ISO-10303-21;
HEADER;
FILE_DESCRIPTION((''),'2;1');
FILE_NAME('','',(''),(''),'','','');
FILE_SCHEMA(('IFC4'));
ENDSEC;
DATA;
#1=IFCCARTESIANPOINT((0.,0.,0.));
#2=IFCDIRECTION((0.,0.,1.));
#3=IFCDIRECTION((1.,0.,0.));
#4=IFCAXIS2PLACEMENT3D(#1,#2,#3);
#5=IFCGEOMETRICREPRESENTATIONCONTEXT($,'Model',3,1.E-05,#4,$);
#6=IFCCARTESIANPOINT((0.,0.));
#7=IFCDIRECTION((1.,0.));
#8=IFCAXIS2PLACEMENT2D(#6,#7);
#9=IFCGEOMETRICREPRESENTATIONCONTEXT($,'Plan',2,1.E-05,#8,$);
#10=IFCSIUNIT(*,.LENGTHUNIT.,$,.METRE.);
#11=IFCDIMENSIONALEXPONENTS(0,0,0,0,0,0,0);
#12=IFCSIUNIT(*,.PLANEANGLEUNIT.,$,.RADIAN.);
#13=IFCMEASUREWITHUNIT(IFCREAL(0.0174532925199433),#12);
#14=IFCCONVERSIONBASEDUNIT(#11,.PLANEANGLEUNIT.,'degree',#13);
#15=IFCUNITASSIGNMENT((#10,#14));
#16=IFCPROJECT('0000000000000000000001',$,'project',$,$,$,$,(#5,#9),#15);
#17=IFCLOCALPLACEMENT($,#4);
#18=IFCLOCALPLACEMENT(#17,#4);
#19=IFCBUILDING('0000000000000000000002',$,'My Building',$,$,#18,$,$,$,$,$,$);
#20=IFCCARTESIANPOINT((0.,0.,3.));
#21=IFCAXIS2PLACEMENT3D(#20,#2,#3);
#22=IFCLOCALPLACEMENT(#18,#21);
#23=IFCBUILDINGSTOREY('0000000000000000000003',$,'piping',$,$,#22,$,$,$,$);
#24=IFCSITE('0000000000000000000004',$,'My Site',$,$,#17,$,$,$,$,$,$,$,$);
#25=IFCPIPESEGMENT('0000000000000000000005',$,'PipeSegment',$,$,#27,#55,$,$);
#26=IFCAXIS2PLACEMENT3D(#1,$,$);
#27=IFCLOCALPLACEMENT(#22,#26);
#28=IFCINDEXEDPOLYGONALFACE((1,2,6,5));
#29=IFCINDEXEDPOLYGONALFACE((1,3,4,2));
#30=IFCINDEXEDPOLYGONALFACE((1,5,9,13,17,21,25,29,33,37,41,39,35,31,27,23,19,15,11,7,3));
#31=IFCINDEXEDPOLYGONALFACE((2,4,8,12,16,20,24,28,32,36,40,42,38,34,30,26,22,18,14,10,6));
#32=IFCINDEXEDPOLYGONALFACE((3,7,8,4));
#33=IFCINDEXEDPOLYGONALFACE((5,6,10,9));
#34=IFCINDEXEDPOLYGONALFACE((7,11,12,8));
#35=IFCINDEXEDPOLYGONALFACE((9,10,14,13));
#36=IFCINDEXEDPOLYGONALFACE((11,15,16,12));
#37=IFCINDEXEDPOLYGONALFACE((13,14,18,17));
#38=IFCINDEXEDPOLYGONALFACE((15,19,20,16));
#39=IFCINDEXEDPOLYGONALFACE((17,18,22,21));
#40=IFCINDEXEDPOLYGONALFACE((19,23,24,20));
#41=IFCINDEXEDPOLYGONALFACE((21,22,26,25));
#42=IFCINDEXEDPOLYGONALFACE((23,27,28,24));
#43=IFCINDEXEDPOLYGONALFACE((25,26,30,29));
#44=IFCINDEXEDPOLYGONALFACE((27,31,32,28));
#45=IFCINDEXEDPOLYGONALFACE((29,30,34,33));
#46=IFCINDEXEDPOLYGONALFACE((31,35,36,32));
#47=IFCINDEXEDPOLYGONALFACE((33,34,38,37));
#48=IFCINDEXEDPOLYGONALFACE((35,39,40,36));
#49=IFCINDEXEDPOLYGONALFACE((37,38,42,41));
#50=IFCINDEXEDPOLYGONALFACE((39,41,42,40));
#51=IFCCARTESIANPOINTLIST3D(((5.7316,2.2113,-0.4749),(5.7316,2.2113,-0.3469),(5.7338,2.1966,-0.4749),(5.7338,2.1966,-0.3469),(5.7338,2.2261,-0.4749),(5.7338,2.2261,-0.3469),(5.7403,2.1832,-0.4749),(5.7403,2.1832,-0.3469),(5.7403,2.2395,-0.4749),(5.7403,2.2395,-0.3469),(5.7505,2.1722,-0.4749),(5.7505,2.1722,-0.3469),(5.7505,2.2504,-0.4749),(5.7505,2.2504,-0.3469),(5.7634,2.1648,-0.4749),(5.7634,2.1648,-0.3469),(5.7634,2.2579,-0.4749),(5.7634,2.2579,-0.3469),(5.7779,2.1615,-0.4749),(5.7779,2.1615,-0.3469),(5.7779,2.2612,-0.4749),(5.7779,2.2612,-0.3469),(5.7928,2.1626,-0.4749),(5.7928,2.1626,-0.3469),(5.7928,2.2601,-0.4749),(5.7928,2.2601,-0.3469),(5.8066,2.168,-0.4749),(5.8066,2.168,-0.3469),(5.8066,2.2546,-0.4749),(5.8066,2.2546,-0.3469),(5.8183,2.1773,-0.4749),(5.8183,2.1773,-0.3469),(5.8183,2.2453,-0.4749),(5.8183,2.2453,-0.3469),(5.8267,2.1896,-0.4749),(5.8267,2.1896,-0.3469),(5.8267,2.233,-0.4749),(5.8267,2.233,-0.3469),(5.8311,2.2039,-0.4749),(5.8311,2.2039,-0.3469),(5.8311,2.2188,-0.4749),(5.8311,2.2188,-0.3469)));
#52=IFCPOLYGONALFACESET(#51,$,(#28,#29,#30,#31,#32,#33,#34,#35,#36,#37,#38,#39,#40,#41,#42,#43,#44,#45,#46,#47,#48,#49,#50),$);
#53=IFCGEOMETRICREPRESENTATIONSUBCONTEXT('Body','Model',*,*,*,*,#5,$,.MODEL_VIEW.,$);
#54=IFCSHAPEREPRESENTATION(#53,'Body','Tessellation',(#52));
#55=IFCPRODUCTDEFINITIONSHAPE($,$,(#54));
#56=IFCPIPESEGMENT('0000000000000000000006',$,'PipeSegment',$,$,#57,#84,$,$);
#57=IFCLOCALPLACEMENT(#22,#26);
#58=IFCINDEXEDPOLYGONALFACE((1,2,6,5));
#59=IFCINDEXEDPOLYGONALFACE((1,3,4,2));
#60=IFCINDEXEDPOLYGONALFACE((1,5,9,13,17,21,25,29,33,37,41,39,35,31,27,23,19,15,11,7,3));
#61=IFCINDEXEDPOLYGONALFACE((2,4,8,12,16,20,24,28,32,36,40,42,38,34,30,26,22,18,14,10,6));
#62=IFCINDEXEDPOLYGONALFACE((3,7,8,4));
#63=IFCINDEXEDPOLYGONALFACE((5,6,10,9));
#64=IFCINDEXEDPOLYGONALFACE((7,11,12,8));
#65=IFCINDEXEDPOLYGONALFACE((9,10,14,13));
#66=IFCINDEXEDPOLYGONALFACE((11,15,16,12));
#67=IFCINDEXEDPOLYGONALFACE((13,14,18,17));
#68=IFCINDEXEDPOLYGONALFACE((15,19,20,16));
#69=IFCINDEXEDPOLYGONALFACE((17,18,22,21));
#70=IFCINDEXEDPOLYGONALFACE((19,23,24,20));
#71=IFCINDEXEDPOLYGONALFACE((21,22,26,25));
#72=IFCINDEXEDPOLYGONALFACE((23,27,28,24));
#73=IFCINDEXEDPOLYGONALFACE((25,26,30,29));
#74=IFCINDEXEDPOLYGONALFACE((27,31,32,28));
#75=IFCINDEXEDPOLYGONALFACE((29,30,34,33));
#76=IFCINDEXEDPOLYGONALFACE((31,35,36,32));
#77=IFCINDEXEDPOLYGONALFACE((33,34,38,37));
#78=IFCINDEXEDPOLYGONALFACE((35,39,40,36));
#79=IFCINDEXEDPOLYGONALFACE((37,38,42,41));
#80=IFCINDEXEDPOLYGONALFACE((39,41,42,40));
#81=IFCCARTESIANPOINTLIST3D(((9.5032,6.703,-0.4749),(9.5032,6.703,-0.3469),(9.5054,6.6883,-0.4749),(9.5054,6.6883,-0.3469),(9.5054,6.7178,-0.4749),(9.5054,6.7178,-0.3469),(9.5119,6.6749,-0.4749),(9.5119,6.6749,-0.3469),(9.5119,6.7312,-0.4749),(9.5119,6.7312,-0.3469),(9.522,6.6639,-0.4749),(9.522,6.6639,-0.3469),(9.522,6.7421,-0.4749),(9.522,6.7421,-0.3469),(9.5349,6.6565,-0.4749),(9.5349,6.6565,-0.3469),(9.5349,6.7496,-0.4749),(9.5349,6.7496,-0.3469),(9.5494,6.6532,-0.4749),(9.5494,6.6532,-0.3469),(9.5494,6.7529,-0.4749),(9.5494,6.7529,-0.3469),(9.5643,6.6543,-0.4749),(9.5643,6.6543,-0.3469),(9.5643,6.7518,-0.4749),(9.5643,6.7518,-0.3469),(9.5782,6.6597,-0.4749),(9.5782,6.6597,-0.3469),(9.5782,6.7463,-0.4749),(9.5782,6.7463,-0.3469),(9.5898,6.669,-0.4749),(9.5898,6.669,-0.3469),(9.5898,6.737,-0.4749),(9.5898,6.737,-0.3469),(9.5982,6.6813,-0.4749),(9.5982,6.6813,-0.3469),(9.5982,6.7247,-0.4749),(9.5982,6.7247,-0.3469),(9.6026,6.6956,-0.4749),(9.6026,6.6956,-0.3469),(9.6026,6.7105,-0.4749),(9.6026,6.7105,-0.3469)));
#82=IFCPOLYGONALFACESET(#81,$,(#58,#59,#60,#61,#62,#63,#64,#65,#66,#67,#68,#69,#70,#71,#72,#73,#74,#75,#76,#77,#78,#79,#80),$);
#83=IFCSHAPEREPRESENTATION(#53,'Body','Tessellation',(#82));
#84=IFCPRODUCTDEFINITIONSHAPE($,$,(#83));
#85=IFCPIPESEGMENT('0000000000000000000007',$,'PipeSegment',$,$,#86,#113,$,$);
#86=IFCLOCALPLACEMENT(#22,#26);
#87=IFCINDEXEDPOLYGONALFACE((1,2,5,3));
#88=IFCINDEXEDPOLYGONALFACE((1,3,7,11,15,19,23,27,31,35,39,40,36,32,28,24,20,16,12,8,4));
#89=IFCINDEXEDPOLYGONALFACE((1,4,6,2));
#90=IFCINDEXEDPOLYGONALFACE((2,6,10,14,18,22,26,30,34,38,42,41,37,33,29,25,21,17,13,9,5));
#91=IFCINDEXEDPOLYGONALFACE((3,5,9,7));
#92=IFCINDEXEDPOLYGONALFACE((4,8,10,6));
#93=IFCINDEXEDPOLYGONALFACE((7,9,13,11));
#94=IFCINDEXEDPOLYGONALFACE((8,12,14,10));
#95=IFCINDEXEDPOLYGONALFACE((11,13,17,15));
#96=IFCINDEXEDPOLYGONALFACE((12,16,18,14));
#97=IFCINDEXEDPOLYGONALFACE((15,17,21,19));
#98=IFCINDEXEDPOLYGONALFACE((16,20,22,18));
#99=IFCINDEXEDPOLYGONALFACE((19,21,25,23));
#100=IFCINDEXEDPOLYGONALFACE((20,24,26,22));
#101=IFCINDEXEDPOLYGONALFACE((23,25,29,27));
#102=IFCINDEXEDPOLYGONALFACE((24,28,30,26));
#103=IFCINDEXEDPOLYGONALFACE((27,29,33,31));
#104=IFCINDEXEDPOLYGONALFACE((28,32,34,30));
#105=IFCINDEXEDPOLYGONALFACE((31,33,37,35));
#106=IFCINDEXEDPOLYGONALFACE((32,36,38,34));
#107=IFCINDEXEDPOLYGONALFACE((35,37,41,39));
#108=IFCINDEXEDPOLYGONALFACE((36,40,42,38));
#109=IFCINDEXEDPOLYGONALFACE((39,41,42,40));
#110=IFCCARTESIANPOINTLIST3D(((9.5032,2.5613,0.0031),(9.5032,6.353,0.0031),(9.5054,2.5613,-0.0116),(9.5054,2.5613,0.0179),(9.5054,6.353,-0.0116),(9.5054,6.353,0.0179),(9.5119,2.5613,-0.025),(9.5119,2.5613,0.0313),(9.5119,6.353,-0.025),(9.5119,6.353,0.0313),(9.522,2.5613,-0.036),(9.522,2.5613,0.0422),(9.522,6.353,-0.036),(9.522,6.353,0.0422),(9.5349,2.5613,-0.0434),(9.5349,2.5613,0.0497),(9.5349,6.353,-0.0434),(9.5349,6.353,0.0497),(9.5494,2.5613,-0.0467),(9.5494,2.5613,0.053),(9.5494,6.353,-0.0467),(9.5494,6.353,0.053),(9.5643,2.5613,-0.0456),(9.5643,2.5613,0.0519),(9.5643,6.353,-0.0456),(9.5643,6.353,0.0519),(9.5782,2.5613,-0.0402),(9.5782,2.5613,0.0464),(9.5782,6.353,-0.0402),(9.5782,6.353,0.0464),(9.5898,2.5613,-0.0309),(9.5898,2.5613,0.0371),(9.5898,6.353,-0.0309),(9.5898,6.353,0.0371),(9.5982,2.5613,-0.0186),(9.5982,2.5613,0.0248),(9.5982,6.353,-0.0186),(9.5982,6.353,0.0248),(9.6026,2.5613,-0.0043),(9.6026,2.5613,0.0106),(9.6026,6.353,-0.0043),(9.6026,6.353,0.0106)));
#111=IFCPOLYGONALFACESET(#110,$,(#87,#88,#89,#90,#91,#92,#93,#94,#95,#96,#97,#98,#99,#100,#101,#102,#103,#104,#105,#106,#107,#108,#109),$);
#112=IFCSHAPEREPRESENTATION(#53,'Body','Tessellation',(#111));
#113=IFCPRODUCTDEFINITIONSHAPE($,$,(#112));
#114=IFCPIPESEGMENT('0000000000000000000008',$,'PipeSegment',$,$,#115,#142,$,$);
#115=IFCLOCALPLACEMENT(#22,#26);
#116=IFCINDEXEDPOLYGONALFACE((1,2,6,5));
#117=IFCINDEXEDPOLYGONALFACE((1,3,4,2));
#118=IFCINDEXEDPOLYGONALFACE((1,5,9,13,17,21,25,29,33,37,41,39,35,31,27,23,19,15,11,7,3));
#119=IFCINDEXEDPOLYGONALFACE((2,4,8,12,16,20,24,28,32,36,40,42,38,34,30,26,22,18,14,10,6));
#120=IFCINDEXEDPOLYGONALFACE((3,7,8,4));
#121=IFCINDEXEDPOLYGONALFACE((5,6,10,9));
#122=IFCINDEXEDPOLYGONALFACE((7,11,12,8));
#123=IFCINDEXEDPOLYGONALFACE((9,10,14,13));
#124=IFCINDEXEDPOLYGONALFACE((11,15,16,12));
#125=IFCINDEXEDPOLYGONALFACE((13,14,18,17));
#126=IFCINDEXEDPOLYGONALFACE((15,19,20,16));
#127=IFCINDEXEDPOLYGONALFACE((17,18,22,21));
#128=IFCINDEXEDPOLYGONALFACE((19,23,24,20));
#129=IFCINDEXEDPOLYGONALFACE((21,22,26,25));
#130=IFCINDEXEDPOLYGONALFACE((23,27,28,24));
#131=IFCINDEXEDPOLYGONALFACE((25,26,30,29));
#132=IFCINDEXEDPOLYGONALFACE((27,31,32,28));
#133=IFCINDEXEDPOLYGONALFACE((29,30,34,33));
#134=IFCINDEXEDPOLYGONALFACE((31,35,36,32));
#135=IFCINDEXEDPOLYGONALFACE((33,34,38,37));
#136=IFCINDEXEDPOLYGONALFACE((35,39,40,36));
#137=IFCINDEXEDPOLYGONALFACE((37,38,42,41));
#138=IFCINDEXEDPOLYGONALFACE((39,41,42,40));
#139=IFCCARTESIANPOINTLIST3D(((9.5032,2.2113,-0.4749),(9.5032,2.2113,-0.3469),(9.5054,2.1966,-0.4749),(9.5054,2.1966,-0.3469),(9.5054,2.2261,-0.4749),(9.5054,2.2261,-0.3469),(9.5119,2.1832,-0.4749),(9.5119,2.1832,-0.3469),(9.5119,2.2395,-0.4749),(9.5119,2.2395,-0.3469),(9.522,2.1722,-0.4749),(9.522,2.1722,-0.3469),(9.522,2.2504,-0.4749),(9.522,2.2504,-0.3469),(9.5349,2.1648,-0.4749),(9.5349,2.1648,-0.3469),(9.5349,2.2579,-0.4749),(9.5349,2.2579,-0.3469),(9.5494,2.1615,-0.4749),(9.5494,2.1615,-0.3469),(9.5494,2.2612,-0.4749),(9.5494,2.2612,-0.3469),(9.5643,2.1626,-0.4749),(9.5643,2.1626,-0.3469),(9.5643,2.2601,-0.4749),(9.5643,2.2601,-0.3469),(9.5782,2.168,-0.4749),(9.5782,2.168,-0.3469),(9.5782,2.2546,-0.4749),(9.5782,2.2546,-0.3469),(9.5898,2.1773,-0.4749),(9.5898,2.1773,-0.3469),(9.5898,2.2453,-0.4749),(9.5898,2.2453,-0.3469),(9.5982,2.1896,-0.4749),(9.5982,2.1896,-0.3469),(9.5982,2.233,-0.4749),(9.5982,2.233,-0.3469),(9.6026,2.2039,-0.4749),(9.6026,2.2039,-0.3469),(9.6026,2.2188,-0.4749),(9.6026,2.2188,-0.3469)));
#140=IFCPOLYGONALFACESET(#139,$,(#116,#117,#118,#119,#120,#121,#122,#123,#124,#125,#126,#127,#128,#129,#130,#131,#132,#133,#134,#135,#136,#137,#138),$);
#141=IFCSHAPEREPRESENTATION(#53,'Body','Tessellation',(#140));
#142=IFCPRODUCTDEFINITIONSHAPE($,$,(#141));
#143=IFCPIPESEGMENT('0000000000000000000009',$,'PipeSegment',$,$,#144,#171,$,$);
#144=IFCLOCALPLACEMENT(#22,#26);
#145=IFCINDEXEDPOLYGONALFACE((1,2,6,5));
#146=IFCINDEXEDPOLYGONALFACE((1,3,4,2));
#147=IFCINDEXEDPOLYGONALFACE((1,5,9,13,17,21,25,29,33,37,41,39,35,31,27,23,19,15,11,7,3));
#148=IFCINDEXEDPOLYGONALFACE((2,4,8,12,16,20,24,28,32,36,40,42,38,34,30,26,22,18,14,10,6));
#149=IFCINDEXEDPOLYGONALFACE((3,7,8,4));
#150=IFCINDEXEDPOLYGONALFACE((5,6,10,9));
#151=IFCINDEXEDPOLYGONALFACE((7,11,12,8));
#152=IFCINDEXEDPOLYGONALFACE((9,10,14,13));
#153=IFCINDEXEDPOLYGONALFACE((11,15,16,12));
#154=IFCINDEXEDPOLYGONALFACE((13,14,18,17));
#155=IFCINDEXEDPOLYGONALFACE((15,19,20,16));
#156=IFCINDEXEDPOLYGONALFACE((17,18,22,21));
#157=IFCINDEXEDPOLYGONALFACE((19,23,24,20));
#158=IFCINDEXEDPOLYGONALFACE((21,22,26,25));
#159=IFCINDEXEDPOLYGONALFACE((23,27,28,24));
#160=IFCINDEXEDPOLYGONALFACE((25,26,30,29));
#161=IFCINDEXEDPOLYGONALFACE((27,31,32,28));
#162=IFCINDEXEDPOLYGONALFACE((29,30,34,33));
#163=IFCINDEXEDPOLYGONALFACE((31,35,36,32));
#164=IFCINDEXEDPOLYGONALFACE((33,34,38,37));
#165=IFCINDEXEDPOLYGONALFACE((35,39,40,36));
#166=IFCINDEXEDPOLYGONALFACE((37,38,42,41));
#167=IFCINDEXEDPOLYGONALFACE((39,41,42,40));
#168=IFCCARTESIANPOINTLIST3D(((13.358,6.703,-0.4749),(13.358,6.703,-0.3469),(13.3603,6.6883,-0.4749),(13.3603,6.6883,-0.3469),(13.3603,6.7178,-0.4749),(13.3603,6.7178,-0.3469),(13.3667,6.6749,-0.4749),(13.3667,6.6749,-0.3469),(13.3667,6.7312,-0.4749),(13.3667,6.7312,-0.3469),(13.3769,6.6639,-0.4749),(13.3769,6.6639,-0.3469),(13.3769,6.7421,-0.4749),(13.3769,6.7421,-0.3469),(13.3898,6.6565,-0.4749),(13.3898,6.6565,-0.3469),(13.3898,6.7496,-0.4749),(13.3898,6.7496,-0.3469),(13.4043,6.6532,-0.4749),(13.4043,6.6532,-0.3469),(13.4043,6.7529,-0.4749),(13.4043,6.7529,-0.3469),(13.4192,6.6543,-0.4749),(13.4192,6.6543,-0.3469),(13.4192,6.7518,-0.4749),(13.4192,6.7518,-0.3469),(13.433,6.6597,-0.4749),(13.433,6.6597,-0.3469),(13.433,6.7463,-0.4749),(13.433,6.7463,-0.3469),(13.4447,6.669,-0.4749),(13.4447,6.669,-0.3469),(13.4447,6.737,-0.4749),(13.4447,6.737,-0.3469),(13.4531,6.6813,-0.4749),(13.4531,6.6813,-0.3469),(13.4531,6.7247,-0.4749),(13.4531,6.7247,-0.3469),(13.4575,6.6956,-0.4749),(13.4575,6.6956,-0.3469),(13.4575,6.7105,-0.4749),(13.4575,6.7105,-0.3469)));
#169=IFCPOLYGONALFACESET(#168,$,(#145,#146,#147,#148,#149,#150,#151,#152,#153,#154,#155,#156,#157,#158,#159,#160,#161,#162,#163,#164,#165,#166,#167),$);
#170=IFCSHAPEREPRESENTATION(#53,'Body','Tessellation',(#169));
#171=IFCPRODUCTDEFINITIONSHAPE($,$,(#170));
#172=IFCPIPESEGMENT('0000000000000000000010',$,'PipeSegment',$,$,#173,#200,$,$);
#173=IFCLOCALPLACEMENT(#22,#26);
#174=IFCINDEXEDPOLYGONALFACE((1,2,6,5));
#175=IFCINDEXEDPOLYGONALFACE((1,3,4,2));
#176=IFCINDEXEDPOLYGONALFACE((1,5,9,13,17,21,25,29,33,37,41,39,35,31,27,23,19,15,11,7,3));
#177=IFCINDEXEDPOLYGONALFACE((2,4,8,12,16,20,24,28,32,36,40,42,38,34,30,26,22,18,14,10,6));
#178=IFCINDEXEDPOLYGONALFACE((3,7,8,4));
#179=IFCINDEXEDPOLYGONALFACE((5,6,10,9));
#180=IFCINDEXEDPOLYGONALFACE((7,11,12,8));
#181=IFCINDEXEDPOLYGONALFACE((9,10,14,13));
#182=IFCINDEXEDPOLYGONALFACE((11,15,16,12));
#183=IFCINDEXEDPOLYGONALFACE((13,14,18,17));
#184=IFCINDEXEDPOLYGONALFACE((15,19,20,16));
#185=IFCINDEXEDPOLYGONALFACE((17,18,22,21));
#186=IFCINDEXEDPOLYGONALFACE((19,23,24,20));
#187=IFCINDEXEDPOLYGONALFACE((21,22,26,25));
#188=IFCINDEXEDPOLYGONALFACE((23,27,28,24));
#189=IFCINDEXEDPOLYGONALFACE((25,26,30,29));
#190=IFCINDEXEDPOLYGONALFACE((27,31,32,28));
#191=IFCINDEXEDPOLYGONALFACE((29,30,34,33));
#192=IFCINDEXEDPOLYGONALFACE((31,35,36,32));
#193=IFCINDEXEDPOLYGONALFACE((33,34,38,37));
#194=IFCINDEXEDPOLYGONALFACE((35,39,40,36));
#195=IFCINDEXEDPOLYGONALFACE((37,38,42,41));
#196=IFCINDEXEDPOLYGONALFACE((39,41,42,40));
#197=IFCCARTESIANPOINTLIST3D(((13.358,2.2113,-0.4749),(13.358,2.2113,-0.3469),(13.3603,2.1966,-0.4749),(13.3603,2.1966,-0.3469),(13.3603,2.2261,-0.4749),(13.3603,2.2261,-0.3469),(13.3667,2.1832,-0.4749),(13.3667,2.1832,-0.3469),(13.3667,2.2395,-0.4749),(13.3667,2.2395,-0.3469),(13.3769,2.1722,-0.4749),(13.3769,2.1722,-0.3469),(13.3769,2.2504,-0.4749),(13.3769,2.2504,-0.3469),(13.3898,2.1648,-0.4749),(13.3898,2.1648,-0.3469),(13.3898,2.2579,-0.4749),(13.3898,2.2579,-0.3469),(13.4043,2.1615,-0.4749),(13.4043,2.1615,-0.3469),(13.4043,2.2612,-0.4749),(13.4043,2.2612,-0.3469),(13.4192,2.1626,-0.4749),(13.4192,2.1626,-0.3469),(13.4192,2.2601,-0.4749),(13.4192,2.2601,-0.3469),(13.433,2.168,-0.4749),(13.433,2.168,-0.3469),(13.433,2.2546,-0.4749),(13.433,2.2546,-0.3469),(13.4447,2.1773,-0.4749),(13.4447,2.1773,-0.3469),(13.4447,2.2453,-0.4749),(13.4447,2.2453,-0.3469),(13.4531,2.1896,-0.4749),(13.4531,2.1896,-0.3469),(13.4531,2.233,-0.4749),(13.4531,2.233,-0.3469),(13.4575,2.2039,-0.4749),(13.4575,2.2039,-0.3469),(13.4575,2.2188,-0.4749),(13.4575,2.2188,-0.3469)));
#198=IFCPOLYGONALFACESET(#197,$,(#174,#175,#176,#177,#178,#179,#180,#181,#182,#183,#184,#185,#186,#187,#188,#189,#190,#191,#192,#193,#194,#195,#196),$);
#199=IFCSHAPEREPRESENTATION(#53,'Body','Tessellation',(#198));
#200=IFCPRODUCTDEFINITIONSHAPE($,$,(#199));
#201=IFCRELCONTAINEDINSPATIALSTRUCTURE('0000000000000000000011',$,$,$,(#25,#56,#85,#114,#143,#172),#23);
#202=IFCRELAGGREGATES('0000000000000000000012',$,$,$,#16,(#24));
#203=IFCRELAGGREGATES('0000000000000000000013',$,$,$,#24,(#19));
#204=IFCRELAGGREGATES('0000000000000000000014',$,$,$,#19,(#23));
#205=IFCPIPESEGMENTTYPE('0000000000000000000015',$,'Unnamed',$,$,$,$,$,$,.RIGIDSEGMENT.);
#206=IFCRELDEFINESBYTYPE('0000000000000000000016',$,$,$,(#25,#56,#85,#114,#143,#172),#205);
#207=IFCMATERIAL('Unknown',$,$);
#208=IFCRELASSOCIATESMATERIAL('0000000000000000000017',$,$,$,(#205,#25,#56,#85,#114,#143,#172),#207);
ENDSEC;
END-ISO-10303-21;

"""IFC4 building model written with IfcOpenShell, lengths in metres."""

from ifc_helpers import new_model, entity, si_unit, converted_unit, frame, origin_with_axes, origin_2d_with_axis, place, context, subcontext, project, spatial, circle, extrude, material, material_profile, profile_set, profile_usage, type_object, element, save


model = new_model("IFC4")

# Units and contexts
model_context = context("Model", 3, precision=1e-05, world=origin_with_axes())
plan_context = context("Plan", 2, precision=1e-05, world=origin_2d_with_axis())
body_context = subcontext(model_context, "Body", "Model", "MODEL_VIEW")
ifc_project = project(units=[si_unit("LENGTHUNIT", "METRE"), converted_unit("PLANEANGLEUNIT", "degree", entity("IfcReal", 0.0174532925199433), si_unit("PLANEANGLEUNIT", "RADIAN"), dimensions=[0, 0, 0, 0, 0, 0, 0])], contexts=[model_context, plan_context])

# Site, building, storey
site_placement = place(None, origin_with_axes())
site = spatial("IfcSite", under=ifc_project, at=site_placement, Name="My Site")
building_placement = place(site_placement, origin_with_axes())
building = spatial("IfcBuilding", under=site, at=building_placement, Name="My Building")
storey_placement = place(building_placement, frame((0.0, 0.0, 3.0), z_axis=(0.0, 0.0, 1.0), x_axis=(1.0, 0.0, 0.0)))
storey = spatial("IfcBuildingStorey", under=building, at=storey_placement, Name="piping")

# Pipe segments
ifc_material = material(Name="Unknown")
ifc_material_profile = material_profile(ifc_material, circle(Radius=0.05))
ifc_profile_set = profile_set([ifc_material_profile])
pipe_segment_type = type_object("IfcPipeSegmentType", Name="Unnamed", PredefinedType="RIGIDSEGMENT", material=ifc_profile_set)
ifc_profile_usage_1 = profile_usage(ifc_profile_set, cardinal=5)
pipe_segment_1_placement = place(storey_placement, frame((5.7816, 2.2113, -0.3469), z_axis=(0.0, 0.0, -1.0), x_axis=(-1.0, 0.0, 0.0)))
element("IfcPipeSegment", 1, at=pipe_segment_1_placement, inside=storey, type_object=pipe_segment_type, material=ifc_profile_usage_1, Name="PipeSegment", context=body_context, shape_type="SweptSolid", body=[
    extrude(circle(Radius=0.05), origin_with_axes(), (0.0, 0.0, 1.0), 0.128),
])
ifc_profile_usage_2 = profile_usage(ifc_profile_set, cardinal=5)
pipe_segment_2_placement = place(storey_placement, frame((9.5532, 6.703, -0.3469), z_axis=(0.0, 0.0, -1.0), x_axis=(-1.0, 0.0, 0.0)))
element("IfcPipeSegment", 2, at=pipe_segment_2_placement, inside=storey, type_object=pipe_segment_type, material=ifc_profile_usage_2, Name="PipeSegment", context=body_context, shape_type="SweptSolid", body=[
    extrude(circle(Radius=0.05), origin_with_axes(), (0.0, 0.0, 1.0), 0.128),
])
ifc_profile_usage_3 = profile_usage(ifc_profile_set, cardinal=5)
pipe_segment_3_placement = place(storey_placement, frame((9.5532, 2.5613, 0.0031), z_axis=(0.0, 1.0, 0.0), x_axis=(-1.0, 0.0, 0.0)))
element("IfcPipeSegment", 3, at=pipe_segment_3_placement, inside=storey, type_object=pipe_segment_type, material=ifc_profile_usage_3, Name="PipeSegment", context=body_context, shape_type="SweptSolid", body=[
    extrude(circle(Radius=0.05), origin_with_axes(), (0.0, 0.0, 1.0), 3.7917),
])
ifc_profile_usage_4 = profile_usage(ifc_profile_set, cardinal=5)
pipe_segment_4_placement = place(storey_placement, frame((9.5532, 2.2113, -0.3469), z_axis=(0.0, 0.0, -1.0), x_axis=(-1.0, 0.0, 0.0)))
element("IfcPipeSegment", 4, at=pipe_segment_4_placement, inside=storey, type_object=pipe_segment_type, material=ifc_profile_usage_4, Name="PipeSegment", context=body_context, shape_type="SweptSolid", body=[
    extrude(circle(Radius=0.05), origin_with_axes(), (0.0, 0.0, 1.0), 0.128),
])
ifc_profile_usage_5 = profile_usage(ifc_profile_set, cardinal=5)
pipe_segment_5_placement = place(storey_placement, frame((13.408, 6.703, -0.3469), z_axis=(0.0, 0.0, -1.0), x_axis=(-1.0, 0.0, 0.0)))
element("IfcPipeSegment", 5, at=pipe_segment_5_placement, inside=storey, type_object=pipe_segment_type, material=ifc_profile_usage_5, Name="PipeSegment", context=body_context, shape_type="SweptSolid", body=[
    extrude(circle(Radius=0.05), origin_with_axes(), (0.0, 0.0, 1.0), 0.128),
])
ifc_profile_usage_6 = profile_usage(ifc_profile_set, cardinal=5)
pipe_segment_6_placement = place(storey_placement, frame((13.408, 2.2113, -0.3469), z_axis=(0.0, 0.0, -1.0), x_axis=(-1.0, 0.0, 0.0)))
element("IfcPipeSegment", 6, at=pipe_segment_6_placement, inside=storey, type_object=pipe_segment_type, material=ifc_profile_usage_6, Name="PipeSegment", context=body_context, shape_type="SweptSolid", body=[
    extrude(circle(Radius=0.05), origin_with_axes(), (0.0, 0.0, 1.0), 0.128),
])

save(model, "model.ifc")
